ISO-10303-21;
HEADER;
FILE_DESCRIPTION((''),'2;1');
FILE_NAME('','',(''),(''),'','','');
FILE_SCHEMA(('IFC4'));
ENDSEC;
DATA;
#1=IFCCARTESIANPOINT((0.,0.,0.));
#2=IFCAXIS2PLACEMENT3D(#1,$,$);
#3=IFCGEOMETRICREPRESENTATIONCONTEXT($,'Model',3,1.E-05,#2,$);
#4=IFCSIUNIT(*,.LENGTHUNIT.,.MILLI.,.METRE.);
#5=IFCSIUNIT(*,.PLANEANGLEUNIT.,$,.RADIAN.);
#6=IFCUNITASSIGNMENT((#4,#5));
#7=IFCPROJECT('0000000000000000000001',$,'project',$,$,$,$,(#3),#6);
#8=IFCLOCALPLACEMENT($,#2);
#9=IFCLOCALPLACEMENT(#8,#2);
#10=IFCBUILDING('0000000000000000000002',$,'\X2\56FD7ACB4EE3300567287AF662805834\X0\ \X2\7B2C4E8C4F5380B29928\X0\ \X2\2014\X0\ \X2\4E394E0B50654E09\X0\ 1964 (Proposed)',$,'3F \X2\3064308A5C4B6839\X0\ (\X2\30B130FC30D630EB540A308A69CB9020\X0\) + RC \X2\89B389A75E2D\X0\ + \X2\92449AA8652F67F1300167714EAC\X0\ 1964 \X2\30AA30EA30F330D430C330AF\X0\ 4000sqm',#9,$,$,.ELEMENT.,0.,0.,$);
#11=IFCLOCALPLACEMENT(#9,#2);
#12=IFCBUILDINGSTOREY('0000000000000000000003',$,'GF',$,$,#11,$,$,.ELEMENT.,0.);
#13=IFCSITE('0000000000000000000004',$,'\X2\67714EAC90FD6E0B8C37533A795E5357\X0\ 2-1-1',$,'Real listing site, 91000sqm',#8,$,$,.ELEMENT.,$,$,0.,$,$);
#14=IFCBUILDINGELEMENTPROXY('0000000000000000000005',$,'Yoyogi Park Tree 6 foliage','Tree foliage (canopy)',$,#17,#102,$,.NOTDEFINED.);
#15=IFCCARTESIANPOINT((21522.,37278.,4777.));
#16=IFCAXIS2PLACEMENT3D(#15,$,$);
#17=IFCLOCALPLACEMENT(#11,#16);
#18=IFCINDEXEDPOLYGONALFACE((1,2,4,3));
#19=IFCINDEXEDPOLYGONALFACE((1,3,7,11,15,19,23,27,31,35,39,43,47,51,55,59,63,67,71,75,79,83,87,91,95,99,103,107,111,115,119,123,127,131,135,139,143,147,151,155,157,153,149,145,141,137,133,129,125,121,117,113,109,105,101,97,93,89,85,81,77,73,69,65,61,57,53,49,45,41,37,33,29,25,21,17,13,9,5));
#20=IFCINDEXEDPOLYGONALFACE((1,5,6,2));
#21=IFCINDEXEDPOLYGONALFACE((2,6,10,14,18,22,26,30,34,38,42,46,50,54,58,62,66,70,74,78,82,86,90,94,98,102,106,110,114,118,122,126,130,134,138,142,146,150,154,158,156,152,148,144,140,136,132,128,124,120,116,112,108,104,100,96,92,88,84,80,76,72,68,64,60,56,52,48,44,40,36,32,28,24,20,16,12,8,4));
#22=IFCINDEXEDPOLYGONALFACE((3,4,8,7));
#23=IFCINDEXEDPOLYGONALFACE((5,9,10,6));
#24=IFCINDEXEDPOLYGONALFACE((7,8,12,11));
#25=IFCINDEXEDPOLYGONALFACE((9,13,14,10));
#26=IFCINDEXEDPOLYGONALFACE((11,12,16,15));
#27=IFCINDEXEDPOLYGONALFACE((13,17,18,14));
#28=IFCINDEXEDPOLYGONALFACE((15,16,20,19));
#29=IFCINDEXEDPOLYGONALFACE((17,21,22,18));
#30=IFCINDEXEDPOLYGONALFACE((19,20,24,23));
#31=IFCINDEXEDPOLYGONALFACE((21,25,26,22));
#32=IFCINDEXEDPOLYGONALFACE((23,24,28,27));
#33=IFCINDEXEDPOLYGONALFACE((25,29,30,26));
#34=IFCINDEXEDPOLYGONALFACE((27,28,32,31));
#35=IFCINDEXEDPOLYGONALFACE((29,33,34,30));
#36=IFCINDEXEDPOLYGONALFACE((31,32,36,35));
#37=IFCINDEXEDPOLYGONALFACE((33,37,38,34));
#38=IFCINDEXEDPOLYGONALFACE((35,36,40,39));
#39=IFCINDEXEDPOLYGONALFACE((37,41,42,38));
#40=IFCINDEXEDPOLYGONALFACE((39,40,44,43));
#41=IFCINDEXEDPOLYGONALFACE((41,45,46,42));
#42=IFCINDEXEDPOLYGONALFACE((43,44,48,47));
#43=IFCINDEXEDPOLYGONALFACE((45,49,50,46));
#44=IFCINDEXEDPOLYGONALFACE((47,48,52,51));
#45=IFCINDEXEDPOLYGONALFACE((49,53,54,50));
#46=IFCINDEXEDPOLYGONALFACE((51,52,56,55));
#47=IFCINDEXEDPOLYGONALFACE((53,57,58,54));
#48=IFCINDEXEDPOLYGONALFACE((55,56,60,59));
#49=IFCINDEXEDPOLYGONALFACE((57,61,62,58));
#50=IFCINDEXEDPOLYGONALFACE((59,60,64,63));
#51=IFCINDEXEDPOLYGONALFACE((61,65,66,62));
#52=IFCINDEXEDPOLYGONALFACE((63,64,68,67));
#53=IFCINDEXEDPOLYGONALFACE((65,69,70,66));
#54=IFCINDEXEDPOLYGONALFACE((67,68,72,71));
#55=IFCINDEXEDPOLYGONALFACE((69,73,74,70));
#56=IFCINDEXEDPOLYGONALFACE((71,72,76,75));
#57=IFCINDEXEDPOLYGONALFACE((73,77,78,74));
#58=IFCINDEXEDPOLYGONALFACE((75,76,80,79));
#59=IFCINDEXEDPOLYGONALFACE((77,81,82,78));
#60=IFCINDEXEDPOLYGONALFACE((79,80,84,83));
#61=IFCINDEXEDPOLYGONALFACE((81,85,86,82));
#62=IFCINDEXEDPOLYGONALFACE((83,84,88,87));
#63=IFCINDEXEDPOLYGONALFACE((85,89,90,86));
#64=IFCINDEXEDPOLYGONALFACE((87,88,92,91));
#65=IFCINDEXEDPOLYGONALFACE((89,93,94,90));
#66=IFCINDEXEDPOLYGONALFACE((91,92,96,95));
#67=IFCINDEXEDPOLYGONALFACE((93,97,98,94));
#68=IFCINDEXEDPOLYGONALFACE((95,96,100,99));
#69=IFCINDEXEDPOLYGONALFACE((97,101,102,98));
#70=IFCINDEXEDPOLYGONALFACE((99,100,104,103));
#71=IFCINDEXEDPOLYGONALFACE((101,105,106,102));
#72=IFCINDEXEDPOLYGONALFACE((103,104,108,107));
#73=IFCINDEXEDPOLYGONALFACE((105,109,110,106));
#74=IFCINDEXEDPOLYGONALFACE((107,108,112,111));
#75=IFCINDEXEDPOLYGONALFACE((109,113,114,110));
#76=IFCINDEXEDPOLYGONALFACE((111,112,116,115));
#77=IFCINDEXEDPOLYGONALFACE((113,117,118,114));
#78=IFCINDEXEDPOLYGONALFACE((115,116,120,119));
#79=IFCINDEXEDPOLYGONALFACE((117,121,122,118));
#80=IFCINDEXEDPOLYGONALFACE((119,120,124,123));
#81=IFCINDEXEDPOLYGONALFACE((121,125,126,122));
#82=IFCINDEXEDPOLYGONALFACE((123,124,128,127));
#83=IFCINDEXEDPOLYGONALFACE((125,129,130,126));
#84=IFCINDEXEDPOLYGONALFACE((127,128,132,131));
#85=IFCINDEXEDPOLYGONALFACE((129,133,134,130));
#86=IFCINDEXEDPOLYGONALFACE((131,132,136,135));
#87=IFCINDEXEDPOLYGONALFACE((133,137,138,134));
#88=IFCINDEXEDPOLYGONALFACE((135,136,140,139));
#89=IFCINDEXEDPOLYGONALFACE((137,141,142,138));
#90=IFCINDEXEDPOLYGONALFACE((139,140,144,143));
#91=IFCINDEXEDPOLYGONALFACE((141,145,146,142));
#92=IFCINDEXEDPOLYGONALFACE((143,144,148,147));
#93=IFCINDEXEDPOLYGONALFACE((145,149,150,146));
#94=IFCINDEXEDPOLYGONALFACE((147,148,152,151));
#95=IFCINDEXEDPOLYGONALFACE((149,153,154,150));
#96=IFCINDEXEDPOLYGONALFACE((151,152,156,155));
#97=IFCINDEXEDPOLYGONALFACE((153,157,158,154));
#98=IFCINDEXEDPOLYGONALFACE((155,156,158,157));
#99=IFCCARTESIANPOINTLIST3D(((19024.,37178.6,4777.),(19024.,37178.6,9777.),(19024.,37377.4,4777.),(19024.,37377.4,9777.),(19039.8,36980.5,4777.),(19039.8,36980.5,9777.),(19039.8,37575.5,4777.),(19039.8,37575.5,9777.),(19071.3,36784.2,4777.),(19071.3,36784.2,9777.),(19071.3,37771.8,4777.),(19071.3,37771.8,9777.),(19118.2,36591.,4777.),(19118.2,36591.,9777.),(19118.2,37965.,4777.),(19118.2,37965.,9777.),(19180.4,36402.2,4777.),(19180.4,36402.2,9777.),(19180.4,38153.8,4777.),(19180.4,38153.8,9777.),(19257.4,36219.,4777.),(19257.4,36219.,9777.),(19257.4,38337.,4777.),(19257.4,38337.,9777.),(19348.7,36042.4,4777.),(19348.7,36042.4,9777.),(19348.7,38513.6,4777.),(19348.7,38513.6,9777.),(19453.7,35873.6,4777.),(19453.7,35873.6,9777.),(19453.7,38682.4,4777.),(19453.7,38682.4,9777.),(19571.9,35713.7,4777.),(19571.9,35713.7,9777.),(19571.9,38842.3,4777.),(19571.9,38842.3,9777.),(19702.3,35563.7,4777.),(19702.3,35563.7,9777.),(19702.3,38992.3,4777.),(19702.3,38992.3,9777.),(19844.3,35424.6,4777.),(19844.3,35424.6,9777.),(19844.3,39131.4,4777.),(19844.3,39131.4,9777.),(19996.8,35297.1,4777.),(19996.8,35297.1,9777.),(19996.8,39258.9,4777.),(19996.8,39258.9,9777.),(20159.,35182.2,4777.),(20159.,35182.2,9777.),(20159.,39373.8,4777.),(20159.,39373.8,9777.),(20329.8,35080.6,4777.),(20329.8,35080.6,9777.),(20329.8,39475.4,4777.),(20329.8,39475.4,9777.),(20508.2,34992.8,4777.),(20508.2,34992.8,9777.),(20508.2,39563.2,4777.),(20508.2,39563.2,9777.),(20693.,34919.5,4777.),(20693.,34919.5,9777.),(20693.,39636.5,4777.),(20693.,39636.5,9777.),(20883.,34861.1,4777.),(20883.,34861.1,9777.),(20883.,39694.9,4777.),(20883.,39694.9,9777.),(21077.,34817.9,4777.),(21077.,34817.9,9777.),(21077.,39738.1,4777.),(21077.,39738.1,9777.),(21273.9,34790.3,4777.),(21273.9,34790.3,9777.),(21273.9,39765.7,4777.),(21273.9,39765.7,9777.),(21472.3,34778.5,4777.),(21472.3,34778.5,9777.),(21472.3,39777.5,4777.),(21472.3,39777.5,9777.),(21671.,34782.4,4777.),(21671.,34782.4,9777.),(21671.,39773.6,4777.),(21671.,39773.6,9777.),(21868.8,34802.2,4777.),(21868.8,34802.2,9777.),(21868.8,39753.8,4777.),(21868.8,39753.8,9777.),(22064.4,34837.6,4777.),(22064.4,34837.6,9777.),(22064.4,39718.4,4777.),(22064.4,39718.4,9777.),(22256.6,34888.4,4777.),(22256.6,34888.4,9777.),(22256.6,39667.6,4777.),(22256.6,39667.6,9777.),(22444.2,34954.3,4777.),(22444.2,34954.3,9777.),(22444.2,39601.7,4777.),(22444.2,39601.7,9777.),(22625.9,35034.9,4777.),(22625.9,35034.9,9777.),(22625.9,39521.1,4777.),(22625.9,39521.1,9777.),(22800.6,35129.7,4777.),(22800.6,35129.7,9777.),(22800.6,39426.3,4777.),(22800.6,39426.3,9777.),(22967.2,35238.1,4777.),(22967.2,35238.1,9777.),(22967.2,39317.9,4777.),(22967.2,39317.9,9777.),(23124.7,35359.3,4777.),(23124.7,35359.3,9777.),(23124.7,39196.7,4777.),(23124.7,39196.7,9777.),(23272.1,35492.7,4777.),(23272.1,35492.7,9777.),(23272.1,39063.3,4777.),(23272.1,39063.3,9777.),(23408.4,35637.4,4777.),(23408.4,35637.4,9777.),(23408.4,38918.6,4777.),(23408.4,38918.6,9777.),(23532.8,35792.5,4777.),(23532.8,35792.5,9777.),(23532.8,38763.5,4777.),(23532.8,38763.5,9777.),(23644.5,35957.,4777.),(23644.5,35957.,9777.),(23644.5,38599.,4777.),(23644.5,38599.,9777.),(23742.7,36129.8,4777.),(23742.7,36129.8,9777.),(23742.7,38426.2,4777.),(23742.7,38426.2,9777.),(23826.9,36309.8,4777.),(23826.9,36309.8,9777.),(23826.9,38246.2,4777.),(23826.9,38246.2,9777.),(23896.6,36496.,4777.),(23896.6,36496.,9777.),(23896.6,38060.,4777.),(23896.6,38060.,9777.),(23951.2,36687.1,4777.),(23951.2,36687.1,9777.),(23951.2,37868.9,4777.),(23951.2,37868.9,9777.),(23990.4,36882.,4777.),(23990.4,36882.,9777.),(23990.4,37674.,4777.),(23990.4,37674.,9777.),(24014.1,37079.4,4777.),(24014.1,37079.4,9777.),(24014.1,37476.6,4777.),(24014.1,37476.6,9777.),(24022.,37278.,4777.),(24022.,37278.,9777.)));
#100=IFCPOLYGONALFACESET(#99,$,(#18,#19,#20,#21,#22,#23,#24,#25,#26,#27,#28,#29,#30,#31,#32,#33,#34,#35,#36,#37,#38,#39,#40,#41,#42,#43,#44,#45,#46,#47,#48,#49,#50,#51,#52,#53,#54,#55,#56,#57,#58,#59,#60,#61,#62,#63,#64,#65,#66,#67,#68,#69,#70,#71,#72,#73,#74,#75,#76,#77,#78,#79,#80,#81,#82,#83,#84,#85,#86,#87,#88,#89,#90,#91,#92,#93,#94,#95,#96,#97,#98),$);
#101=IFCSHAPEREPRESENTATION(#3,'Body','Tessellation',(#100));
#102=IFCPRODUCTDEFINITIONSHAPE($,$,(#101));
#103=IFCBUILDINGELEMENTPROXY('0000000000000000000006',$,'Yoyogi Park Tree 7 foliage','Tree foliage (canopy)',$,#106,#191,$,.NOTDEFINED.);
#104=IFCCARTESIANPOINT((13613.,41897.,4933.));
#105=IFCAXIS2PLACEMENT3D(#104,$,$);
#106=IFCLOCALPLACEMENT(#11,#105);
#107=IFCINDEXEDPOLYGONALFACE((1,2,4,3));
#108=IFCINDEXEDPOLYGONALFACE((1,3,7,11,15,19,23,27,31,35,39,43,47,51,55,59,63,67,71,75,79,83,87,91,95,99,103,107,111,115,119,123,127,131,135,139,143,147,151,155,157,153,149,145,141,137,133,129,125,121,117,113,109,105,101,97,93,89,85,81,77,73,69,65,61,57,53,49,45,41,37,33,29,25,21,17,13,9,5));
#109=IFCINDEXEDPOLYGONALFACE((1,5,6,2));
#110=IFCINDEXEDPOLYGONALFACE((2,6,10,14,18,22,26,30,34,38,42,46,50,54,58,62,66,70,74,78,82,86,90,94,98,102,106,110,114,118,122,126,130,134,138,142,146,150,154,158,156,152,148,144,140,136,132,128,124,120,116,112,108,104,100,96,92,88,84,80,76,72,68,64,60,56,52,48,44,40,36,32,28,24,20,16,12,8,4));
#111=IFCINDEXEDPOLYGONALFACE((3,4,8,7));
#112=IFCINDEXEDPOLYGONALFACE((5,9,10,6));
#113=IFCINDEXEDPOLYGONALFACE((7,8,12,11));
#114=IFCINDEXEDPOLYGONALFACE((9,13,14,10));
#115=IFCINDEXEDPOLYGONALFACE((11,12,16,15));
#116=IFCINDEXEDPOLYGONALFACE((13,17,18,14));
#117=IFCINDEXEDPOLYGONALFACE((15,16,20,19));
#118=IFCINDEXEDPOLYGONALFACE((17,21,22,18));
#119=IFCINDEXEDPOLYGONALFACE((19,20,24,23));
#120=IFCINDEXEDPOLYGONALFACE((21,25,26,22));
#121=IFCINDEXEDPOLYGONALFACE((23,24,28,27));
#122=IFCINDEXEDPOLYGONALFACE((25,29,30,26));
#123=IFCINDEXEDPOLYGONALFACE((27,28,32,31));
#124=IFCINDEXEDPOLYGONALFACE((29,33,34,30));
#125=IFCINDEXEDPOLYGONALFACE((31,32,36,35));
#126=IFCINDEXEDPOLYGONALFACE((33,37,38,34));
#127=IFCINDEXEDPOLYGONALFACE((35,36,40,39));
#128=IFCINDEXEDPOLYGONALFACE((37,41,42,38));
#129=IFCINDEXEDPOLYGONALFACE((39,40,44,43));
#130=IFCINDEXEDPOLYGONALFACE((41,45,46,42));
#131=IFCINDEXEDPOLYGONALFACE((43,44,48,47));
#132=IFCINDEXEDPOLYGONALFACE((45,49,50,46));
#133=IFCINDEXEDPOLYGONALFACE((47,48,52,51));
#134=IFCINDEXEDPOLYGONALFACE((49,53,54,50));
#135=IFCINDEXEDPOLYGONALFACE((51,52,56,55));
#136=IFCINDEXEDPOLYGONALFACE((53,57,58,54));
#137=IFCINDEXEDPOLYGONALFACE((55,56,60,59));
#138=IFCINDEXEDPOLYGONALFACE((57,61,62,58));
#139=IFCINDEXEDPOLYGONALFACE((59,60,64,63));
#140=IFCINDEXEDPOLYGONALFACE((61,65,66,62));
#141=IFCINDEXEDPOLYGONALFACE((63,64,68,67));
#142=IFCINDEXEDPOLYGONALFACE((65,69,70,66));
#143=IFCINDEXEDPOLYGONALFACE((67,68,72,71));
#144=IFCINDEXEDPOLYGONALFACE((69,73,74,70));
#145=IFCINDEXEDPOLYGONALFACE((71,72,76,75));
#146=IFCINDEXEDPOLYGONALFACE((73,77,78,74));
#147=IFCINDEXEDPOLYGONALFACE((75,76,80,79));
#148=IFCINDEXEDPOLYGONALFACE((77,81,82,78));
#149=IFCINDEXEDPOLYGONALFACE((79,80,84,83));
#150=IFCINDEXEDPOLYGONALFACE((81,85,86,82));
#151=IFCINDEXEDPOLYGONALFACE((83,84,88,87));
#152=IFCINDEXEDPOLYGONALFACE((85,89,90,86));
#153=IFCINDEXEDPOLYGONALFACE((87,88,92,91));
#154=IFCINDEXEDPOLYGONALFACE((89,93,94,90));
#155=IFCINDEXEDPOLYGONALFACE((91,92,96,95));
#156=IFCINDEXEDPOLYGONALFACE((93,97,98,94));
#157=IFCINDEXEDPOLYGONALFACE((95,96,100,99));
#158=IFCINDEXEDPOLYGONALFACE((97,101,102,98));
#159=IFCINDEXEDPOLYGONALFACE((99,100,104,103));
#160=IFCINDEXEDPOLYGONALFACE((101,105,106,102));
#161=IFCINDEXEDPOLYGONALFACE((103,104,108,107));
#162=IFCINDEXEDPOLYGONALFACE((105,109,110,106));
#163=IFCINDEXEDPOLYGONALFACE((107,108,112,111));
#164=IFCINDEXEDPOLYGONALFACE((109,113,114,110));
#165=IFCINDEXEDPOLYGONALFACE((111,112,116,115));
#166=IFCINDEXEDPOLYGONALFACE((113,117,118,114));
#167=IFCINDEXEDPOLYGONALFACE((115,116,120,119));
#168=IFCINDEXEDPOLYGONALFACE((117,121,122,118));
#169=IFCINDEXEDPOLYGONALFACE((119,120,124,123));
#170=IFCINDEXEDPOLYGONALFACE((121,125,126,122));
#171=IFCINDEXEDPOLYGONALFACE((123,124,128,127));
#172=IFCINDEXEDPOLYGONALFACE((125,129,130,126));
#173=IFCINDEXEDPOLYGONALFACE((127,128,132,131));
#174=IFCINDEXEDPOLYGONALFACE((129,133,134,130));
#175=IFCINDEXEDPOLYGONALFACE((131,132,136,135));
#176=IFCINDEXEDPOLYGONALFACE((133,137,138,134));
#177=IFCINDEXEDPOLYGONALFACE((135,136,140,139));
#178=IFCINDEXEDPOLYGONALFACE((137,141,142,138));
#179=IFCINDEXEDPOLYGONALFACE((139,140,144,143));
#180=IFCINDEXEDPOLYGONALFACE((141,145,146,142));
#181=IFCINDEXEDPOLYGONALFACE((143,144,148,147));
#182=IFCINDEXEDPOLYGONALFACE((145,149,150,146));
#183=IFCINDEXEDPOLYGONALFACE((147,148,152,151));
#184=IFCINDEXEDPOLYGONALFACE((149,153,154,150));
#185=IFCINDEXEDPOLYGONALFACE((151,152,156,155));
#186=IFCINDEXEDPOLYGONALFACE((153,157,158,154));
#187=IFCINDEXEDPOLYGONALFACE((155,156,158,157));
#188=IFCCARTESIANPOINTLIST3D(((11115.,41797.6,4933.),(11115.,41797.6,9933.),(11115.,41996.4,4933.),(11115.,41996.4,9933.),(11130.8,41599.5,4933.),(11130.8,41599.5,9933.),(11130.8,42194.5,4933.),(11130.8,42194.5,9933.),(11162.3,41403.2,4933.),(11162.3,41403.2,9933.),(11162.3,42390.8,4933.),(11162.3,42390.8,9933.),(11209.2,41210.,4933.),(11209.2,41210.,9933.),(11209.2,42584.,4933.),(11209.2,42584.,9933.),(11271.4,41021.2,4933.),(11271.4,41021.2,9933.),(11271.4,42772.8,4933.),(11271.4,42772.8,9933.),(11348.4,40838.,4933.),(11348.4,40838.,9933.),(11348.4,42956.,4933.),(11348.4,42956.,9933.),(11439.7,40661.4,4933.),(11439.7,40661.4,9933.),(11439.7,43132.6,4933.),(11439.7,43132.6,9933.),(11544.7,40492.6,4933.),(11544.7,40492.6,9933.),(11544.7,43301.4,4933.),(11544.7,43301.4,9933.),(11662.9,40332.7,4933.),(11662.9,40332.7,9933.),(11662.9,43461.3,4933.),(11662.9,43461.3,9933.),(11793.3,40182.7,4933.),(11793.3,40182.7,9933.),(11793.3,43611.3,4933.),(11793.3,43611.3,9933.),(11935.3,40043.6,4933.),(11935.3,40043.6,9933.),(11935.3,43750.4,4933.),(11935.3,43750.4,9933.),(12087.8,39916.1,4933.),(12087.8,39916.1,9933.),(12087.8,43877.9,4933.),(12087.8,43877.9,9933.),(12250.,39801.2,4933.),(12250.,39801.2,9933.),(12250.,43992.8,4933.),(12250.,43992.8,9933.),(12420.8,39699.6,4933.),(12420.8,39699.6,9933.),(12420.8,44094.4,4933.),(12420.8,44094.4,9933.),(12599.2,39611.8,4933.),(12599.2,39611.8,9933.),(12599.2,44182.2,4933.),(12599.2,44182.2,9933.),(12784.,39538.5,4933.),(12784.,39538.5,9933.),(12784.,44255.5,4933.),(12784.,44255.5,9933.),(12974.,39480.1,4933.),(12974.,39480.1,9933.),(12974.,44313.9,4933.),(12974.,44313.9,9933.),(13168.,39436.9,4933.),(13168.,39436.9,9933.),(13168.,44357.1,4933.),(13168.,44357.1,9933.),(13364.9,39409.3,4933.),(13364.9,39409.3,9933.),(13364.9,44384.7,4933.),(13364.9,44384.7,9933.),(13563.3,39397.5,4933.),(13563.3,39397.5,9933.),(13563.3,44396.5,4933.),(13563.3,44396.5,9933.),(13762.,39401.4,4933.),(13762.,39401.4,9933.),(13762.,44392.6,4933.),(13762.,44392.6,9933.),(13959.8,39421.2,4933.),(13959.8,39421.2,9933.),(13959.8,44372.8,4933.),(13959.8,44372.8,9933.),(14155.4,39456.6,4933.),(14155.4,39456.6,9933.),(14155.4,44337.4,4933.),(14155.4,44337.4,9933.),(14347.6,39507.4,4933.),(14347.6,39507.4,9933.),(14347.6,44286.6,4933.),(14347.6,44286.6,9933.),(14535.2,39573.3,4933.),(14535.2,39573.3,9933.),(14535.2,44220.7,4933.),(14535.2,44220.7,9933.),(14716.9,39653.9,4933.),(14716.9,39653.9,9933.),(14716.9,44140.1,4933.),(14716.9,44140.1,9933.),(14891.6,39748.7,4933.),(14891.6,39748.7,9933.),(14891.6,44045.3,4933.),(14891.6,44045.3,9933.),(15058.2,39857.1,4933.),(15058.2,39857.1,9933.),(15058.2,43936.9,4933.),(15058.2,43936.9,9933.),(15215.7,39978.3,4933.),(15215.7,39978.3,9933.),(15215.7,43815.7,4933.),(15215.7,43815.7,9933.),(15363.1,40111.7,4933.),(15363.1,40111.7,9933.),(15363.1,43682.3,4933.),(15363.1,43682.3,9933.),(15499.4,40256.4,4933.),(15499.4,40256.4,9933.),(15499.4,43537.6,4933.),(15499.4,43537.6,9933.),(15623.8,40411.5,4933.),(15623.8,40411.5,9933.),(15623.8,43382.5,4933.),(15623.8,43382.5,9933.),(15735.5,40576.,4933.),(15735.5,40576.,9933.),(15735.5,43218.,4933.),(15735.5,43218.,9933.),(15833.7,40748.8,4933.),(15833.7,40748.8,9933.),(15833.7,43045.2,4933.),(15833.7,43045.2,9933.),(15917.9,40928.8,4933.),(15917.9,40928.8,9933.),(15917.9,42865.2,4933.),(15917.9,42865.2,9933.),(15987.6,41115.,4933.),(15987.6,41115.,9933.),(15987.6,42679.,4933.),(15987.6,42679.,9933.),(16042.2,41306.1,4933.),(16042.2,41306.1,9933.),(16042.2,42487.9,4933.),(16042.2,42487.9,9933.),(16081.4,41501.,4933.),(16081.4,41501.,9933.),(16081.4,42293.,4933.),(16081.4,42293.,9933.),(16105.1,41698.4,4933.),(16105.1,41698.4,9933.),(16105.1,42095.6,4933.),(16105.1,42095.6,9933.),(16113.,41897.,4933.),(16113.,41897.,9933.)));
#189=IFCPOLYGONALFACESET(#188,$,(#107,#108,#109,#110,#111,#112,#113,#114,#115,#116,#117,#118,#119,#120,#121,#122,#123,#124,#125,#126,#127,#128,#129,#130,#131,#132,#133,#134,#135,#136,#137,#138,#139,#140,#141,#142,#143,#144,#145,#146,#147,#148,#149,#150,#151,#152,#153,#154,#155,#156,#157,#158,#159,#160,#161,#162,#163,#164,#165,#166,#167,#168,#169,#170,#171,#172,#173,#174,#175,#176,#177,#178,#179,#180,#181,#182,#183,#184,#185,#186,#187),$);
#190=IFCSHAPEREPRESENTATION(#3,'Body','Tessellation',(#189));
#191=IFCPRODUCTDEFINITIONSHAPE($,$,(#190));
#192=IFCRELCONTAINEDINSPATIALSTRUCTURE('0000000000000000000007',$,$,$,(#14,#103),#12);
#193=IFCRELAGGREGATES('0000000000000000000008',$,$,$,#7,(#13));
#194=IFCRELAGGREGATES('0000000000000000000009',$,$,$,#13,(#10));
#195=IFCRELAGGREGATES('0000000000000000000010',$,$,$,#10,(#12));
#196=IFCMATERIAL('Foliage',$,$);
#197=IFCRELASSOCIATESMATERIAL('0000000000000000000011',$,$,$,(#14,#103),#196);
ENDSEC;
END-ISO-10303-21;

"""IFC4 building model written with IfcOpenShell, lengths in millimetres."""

from ifc_helpers import new_model, si_unit, frame, origin, origin_2d, place, context, project, spatial, circle, extrude, material, element, save


model = new_model("IFC4")

# Units and contexts
model_context = context("Model", 3, precision=1e-05, world=origin())
ifc_project = project(units=[si_unit("LENGTHUNIT", "METRE", prefix="MILLI"), si_unit("PLANEANGLEUNIT", "RADIAN")], contexts=[model_context])

# Site, building, storey
site_placement = place(None, origin())
site = spatial("IfcSite", under=ifc_project, at=site_placement, Name="東京都渋谷区神南 2-1-1", ObjectType="Real listing site, 91000sqm", CompositionType="ELEMENT", RefElevation=0.0)
building_placement = place(site_placement, origin())
building = spatial("IfcBuilding", under=site, at=building_placement, Name="国立代々木競技場 第二体育館 — 丹下健三 1964 (Proposed)", ObjectType="3F つり屋根 (ケーブル吊り構造) + RC 観覧席 + 鉄骨支柱、東京 1964 オリンピック 4000sqm", CompositionType="ELEMENT", ElevationOfRefHeight=0.0, ElevationOfTerrain=0.0)
storey_placement = place(building_placement, origin())
storey = spatial("IfcBuildingStorey", under=building, at=storey_placement, Name="GF", CompositionType="ELEMENT", Elevation=0.0)

# Building element proxies
ifc_material_1 = material(Name="Foliage")
proxy_1_placement = place(storey_placement, frame((21522.0, 37278.0, 4777.0)))
element("IfcBuildingElementProxy", 1, at=proxy_1_placement, inside=storey, material=ifc_material_1, Name="Yoyogi Park Tree 6 foliage", Description="Tree foliage (canopy)", PredefinedType="NOTDEFINED", context=model_context, shape_type="SweptSolid", body=[
    extrude(circle(Radius=2500.0, at=origin_2d()), frame((21522.0, 37278.0, 4777.0)), (0.0, 0.0, 1.0), 5000.0),
])
proxy_2_placement = place(storey_placement, frame((13613.0, 41897.0, 4933.0)))
element("IfcBuildingElementProxy", 2, at=proxy_2_placement, inside=storey, material=ifc_material_1, Name="Yoyogi Park Tree 7 foliage", Description="Tree foliage (canopy)", PredefinedType="NOTDEFINED", context=model_context, shape_type="SweptSolid", body=[
    extrude(circle(Radius=2500.0, at=origin_2d()), frame((13613.0, 41897.0, 4933.0)), (0.0, 0.0, 1.0), 5000.0),
])

save(model, "model.ifc")
